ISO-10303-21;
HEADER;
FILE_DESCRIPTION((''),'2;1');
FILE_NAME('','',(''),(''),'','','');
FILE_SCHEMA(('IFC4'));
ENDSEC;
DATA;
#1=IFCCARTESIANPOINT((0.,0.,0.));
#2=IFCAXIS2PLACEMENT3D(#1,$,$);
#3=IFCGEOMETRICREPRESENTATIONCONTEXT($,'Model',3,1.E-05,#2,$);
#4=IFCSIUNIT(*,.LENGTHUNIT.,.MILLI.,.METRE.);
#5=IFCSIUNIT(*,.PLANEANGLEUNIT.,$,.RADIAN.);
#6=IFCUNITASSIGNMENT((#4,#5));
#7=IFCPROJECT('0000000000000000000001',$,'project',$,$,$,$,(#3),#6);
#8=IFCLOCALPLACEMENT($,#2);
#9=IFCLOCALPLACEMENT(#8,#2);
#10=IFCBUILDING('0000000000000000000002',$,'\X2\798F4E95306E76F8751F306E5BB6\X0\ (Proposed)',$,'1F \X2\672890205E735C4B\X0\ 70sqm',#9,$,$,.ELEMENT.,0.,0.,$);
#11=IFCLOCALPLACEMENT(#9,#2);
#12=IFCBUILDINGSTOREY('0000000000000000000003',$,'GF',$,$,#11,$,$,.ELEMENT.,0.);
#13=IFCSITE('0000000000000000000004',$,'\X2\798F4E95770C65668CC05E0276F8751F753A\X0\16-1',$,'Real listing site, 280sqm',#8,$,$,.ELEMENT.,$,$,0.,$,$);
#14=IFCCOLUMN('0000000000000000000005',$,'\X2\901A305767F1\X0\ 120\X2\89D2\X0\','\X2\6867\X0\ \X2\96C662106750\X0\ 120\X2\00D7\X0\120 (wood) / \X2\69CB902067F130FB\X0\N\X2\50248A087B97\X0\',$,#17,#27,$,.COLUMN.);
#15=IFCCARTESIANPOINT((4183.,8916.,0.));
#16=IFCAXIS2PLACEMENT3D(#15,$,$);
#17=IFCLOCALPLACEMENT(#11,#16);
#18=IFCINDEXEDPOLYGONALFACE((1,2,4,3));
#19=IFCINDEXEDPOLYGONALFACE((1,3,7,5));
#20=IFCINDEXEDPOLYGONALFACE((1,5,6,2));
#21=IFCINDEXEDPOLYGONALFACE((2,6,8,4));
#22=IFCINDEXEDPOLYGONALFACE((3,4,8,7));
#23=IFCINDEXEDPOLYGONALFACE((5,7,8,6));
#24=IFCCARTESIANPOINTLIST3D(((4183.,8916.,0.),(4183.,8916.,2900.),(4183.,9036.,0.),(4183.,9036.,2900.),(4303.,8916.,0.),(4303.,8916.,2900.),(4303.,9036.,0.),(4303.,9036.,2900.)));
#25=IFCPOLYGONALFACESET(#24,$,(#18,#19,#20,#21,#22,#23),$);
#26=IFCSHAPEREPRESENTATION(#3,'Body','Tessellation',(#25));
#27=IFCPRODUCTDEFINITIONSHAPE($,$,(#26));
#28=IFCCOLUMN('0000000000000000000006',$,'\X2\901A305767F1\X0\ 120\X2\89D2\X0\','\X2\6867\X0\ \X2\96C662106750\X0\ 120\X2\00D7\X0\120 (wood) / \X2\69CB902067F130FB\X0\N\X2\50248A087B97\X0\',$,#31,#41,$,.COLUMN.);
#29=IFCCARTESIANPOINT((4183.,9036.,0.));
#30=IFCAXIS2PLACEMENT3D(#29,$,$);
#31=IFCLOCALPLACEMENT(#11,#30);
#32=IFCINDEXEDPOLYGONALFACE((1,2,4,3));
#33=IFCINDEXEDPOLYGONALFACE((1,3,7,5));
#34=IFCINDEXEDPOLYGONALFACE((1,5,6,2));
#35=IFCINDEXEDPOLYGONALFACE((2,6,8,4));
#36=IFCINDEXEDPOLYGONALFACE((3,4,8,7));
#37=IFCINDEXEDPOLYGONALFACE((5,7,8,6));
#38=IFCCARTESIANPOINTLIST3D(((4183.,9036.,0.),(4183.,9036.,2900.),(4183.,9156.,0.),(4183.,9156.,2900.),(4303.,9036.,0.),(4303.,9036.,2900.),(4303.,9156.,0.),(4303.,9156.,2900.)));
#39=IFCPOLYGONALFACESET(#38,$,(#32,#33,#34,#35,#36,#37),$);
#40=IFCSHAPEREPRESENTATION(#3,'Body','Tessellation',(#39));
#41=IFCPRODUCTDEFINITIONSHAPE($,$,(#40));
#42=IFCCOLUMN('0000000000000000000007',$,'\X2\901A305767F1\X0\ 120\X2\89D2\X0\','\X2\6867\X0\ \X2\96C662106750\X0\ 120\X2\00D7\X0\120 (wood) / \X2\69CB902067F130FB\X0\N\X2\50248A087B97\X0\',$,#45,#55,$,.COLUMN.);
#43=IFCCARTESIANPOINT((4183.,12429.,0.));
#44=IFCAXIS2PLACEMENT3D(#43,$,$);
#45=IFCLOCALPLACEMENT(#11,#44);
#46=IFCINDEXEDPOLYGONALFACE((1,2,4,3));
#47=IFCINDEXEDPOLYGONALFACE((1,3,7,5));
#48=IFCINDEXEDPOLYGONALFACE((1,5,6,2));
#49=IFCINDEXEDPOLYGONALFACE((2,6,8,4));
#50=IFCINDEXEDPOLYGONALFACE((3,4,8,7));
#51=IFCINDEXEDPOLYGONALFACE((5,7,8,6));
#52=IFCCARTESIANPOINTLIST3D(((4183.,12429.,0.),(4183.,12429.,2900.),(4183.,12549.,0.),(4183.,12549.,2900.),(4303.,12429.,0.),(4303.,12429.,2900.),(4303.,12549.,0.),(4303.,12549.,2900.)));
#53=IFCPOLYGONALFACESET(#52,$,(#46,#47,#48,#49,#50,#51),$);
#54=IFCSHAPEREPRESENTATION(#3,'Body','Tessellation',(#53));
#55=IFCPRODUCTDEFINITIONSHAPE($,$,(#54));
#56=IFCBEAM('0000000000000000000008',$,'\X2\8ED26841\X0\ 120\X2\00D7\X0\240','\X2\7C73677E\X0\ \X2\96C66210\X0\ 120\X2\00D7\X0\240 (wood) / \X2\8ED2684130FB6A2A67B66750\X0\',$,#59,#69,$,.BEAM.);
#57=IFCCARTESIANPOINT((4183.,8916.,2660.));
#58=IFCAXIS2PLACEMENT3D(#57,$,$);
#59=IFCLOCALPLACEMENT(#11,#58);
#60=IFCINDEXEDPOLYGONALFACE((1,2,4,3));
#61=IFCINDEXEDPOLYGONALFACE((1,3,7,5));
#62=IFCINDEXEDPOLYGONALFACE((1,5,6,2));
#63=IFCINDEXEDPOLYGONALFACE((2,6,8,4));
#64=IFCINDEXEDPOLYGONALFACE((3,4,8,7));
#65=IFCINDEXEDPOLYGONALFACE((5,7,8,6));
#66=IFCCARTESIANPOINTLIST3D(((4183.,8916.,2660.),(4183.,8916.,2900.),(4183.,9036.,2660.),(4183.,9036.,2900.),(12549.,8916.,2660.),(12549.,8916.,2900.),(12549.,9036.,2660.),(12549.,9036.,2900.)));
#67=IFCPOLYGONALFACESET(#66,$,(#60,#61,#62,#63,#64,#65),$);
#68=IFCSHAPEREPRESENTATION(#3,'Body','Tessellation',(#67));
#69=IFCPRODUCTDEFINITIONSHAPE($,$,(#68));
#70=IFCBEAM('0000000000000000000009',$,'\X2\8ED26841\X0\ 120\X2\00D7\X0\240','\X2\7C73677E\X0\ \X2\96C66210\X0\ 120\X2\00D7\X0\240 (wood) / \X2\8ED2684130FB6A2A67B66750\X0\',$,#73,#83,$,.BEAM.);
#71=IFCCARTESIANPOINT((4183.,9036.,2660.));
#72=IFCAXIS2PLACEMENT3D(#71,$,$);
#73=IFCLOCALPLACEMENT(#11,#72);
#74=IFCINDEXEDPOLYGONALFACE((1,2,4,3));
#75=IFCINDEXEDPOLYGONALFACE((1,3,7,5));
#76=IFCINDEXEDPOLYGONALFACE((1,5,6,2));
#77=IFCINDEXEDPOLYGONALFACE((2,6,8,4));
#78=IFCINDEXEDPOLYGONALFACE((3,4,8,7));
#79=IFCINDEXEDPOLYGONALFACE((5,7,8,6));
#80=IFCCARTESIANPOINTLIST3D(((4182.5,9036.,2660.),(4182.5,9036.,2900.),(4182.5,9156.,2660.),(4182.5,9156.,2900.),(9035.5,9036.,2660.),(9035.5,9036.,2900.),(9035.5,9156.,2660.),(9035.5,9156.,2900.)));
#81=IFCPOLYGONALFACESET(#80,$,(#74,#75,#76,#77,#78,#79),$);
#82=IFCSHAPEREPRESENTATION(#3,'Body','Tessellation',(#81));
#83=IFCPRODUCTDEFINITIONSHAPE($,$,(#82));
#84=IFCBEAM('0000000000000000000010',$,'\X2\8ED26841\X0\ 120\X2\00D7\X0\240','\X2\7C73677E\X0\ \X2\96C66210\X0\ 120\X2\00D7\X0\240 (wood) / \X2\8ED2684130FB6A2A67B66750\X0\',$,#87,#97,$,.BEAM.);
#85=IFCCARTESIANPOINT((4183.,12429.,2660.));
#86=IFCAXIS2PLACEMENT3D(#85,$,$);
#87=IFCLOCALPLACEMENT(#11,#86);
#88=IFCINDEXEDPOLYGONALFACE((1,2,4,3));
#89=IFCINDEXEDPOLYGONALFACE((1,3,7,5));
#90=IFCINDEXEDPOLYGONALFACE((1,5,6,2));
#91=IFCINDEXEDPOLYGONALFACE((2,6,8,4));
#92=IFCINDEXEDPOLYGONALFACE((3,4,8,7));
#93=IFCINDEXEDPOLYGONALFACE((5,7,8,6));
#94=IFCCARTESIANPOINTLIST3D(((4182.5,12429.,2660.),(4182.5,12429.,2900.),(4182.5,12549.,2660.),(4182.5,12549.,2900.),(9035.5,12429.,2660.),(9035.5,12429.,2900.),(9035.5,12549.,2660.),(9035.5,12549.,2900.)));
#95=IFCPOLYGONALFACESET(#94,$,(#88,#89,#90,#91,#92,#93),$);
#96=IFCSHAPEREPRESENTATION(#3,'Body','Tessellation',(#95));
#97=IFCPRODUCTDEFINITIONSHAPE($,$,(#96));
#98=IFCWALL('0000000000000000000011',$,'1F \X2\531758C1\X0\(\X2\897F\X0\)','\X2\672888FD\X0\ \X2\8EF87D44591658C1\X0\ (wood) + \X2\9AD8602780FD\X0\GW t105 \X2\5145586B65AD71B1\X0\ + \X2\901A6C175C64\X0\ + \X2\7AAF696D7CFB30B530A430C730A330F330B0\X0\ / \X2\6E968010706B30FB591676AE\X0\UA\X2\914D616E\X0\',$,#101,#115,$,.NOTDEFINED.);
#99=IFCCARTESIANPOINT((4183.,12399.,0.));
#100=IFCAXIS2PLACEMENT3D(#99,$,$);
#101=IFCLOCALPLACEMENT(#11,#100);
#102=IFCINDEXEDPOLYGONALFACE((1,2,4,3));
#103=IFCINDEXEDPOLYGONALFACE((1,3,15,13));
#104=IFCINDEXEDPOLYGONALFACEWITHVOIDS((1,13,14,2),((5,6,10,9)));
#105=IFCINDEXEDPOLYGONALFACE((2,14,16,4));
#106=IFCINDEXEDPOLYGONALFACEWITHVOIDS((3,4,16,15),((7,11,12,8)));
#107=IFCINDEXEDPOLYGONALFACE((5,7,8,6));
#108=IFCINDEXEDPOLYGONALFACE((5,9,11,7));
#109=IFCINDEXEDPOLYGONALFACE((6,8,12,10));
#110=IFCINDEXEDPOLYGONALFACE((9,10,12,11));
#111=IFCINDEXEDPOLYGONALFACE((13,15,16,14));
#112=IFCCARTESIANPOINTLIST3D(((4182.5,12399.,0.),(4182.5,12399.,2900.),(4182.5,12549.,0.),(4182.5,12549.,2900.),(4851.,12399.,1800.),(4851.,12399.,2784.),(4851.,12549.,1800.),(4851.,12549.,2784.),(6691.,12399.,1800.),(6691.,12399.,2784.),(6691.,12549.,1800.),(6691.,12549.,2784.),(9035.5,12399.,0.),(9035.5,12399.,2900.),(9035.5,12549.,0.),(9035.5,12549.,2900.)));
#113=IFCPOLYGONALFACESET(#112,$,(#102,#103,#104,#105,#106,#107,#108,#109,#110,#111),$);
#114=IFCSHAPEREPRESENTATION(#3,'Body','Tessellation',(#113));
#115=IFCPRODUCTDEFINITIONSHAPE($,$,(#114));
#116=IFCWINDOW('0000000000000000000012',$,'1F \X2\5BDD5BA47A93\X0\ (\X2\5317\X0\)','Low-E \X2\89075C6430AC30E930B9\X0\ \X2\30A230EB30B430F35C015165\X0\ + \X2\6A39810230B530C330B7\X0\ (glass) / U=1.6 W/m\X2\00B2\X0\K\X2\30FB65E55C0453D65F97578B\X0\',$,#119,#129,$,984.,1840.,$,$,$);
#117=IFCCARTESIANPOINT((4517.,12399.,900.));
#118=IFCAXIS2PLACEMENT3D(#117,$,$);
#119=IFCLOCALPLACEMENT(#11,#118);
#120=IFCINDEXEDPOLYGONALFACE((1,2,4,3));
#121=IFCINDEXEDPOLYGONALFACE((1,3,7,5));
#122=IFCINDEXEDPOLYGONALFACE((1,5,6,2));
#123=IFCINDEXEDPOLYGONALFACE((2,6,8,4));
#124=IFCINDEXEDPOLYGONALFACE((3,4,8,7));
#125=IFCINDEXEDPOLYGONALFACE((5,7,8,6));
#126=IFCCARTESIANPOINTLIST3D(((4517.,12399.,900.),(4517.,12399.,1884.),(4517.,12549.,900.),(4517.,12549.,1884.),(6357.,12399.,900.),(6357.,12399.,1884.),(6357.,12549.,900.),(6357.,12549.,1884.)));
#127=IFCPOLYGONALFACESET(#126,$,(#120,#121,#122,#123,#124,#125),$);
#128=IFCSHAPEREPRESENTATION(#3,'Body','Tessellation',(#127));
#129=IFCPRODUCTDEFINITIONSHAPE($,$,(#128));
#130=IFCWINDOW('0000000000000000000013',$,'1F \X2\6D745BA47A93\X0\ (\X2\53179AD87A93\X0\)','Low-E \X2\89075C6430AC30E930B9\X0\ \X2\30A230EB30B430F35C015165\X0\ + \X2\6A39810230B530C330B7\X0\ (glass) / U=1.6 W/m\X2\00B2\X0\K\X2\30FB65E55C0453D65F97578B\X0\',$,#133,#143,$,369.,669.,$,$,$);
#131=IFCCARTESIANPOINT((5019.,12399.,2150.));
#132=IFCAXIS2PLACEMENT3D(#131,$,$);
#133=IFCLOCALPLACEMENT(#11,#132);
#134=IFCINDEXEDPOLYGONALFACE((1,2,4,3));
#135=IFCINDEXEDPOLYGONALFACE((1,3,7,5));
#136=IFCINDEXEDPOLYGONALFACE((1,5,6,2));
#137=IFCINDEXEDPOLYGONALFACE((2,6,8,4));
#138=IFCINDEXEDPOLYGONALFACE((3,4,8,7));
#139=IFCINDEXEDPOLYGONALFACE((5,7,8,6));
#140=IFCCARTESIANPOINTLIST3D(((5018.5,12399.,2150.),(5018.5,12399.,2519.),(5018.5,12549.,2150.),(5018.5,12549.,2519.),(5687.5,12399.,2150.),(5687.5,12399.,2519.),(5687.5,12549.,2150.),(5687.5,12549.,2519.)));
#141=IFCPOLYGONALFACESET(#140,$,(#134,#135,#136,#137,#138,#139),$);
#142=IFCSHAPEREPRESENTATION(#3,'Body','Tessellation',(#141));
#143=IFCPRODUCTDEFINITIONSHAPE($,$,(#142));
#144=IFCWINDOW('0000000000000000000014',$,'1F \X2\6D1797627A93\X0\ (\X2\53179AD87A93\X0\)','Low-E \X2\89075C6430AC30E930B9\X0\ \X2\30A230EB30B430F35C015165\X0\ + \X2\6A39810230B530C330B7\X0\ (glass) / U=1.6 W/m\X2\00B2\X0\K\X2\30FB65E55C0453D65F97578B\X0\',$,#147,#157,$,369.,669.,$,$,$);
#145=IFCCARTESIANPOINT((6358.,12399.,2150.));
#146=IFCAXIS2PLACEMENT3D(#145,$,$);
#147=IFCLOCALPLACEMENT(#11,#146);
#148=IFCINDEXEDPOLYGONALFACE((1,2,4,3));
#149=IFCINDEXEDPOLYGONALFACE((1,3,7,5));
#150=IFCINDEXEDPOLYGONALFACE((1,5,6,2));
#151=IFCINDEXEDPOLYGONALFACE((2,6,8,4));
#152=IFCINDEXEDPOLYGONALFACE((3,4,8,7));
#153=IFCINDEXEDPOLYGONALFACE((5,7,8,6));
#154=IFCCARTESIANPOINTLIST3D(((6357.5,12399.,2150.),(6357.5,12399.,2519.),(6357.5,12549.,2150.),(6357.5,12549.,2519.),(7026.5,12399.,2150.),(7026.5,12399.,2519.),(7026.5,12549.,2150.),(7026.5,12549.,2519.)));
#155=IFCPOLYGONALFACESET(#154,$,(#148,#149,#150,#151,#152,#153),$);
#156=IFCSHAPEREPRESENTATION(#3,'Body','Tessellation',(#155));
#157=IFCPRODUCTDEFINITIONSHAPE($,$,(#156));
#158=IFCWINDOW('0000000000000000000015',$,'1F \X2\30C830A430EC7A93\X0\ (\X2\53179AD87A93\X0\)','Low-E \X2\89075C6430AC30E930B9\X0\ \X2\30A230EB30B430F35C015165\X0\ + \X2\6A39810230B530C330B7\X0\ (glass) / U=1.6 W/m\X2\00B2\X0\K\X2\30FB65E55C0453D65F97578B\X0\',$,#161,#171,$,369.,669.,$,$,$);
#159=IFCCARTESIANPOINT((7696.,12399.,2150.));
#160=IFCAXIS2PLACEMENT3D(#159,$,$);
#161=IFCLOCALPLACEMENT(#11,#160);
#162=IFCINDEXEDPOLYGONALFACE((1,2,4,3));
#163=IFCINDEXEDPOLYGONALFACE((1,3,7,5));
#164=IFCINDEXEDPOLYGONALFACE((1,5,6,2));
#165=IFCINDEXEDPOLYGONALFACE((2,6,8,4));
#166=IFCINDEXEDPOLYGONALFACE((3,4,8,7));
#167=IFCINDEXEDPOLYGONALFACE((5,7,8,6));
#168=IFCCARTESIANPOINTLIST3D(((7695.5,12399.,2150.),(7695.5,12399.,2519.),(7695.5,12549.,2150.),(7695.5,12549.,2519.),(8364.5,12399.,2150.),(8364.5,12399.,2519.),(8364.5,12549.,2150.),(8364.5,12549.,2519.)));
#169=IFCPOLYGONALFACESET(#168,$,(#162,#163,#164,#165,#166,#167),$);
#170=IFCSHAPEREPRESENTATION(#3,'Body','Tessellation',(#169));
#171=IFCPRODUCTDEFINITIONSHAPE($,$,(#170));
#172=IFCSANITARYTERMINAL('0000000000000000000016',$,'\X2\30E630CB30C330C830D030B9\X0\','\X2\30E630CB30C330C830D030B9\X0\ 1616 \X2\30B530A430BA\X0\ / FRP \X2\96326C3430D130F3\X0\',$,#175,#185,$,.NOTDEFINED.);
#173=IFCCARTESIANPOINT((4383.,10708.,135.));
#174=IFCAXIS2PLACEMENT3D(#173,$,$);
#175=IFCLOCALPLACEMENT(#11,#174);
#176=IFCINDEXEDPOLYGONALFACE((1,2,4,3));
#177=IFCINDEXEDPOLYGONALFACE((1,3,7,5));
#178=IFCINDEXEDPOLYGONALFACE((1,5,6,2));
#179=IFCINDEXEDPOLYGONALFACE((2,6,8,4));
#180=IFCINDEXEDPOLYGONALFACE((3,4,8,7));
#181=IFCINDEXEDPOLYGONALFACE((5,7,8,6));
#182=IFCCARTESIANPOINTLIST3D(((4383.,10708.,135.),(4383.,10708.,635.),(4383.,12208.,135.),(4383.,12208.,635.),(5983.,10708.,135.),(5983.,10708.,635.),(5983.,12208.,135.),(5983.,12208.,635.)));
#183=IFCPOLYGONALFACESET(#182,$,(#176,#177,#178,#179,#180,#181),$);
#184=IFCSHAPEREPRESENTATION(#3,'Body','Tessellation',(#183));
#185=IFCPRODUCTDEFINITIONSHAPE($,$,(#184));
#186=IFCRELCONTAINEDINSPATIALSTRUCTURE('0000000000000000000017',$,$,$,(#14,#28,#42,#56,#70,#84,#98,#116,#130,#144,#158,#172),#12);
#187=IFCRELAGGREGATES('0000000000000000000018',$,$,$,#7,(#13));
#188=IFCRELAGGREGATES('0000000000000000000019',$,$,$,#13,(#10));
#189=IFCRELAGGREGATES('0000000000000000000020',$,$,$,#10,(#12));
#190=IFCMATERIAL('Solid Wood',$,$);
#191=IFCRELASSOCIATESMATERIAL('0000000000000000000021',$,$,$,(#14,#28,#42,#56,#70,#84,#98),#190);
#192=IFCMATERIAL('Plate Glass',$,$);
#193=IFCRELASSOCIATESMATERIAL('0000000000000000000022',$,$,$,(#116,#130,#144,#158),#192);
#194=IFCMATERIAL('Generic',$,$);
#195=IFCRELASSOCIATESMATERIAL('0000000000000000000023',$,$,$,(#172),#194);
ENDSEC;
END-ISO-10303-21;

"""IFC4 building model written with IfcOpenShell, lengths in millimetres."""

from ifc_helpers import new_model, si_unit, frame, frame_2d, origin, place, context, project, spatial, rectangle, extrude, material, element, fill, save


model = new_model("IFC4")

# Units and contexts
model_context = context("Model", 3, precision=1e-05, world=origin())
ifc_project = project(units=[si_unit("LENGTHUNIT", "METRE", prefix="MILLI"), si_unit("PLANEANGLEUNIT", "RADIAN")], contexts=[model_context])

# Site, building, storey
site_placement = place(None, origin())
site = spatial("IfcSite", under=ifc_project, at=site_placement, Name="福井県敦賀市相生町16-1", ObjectType="Real listing site, 280sqm", CompositionType="ELEMENT", RefElevation=0.0)
building_placement = place(site_placement, origin())
building = spatial("IfcBuilding", under=site, at=building_placement, Name="福井の相生の家 (Proposed)", ObjectType="1F 木造平屋 70sqm", CompositionType="ELEMENT", ElevationOfRefHeight=0.0, ElevationOfTerrain=0.0)
storey_placement = place(building_placement, origin())
storey = spatial("IfcBuildingStorey", under=building, at=storey_placement, Name="GF", CompositionType="ELEMENT", Elevation=0.0)

# Columns
ifc_material_1 = material(Name="Solid Wood")
column_1_placement = place(storey_placement, frame((4183.0, 8916.0, 0.0)))
element("IfcColumn", 1, at=column_1_placement, inside=storey, material=ifc_material_1, Name="通し柱 120角", Description="桧 集成材 120×120 (wood) / 構造柱・N値計算", PredefinedType="COLUMN", context=model_context, shape_type="SweptSolid", body=[
    extrude(rectangle(XDim=120.0, YDim=120.0, at=frame_2d((60.0, 60.0))), frame((4183.0, 8916.0, 0.0)), (0.0, 0.0, 1.0), 2900.0),
])
column_2_placement = place(storey_placement, frame((4183.0, 9036.0, 0.0)))
element("IfcColumn", 2, at=column_2_placement, inside=storey, material=ifc_material_1, Name="通し柱 120角", Description="桧 集成材 120×120 (wood) / 構造柱・N値計算", PredefinedType="COLUMN", context=model_context, shape_type="SweptSolid", body=[
    extrude(rectangle(XDim=120.0, YDim=120.0, at=frame_2d((60.0, 60.0))), frame((4183.0, 9036.0, 0.0)), (0.0, 0.0, 1.0), 2900.0),
])
column_3_placement = place(storey_placement, frame((4183.0, 12429.0, 0.0)))
element("IfcColumn", 3, at=column_3_placement, inside=storey, material=ifc_material_1, Name="通し柱 120角", Description="桧 集成材 120×120 (wood) / 構造柱・N値計算", PredefinedType="COLUMN", context=model_context, shape_type="SweptSolid", body=[
    extrude(rectangle(XDim=120.0, YDim=120.0, at=frame_2d((60.0, 60.0))), frame((4183.0, 12429.0, 0.0)), (0.0, 0.0, 1.0), 2900.0),
])

# Beams
beam_1_placement = place(storey_placement, frame((4183.0, 8916.0, 2660.0)))
element("IfcBeam", 4, at=beam_1_placement, inside=storey, material=ifc_material_1, Name="軒桁 120×240", Description="米松 集成 120×240 (wood) / 軒桁・横架材", PredefinedType="BEAM", context=model_context, shape_type="SweptSolid", body=[
    extrude(rectangle(XDim=8366.0, YDim=120.0, at=frame_2d((4183.0, 60.0))), frame((4183.0, 8916.0, 2660.0)), (0.0, 0.0, 1.0), 240.0),
])
beam_2_placement = place(storey_placement, frame((4183.0, 9036.0, 2660.0)))
element("IfcBeam", 5, at=beam_2_placement, inside=storey, material=ifc_material_1, Name="軒桁 120×240", Description="米松 集成 120×240 (wood) / 軒桁・横架材", PredefinedType="BEAM", context=model_context, shape_type="SweptSolid", body=[
    extrude(rectangle(XDim=4853.0, YDim=120.0, at=frame_2d((2426.0, 60.0))), frame((4183.0, 9036.0, 2660.0)), (0.0, 0.0, 1.0), 240.0),
])
beam_3_placement = place(storey_placement, frame((4183.0, 12429.0, 2660.0)))
element("IfcBeam", 6, at=beam_3_placement, inside=storey, material=ifc_material_1, Name="軒桁 120×240", Description="米松 集成 120×240 (wood) / 軒桁・横架材", PredefinedType="BEAM", context=model_context, shape_type="SweptSolid", body=[
    extrude(rectangle(XDim=4853.0, YDim=120.0, at=frame_2d((2426.0, 60.0))), frame((4183.0, 12429.0, 2660.0)), (0.0, 0.0, 1.0), 240.0),
])

# Wall, openings, windows
wall_1_placement = place(storey_placement, frame((4183.0, 12399.0, 0.0)))
wall_1 = element("IfcWall", 7, at=wall_1_placement, inside=storey, material=ifc_material_1, Name="1F 北壁(西)", Description="木製 軸組外壁 (wood) + 高性能GW t105 充填断熱 + 通気層 + 窯業系サイディング / 準耐火・外皮UA配慮", PredefinedType="NOTDEFINED", context=model_context, shape_type="SweptSolid", body=[
    extrude(rectangle(XDim=4853.0, YDim=150.0, at=frame_2d((2426.0, 75.0))), frame((4183.0, 12399.0, 0.0)), (0.0, 0.0, 1.0), 2900.0),
])
opening_1_placement = place(storey_placement, frame((4517.0, 12399.0, 900.0)))
opening_1 = element("IfcOpeningElement", 8, at=opening_1_placement, cuts=wall_1, PredefinedType="NOTDEFINED", context=model_context, shape_type="SweptSolid", body=[
    extrude(rectangle(XDim=1840.0, YDim=150.0, at=frame_2d((920.0, 75.0))), frame((4517.0, 12399.0, 900.0)), (0.0, 0.0, 1.0), 984.0),
])
opening_2_placement = place(storey_placement, frame((5019.0, 12399.0, 2150.0)))
opening_2 = element("IfcOpeningElement", 9, at=opening_2_placement, cuts=wall_1, PredefinedType="NOTDEFINED", context=model_context, shape_type="SweptSolid", body=[
    extrude(rectangle(XDim=669.0, YDim=150.0, at=frame_2d((334.0, 75.0))), frame((5019.0, 12399.0, 2150.0)), (0.0, 0.0, 1.0), 369.0),
])
opening_3_placement = place(storey_placement, frame((6358.0, 12399.0, 2150.0)))
opening_3 = element("IfcOpeningElement", 10, at=opening_3_placement, cuts=wall_1, PredefinedType="NOTDEFINED", context=model_context, shape_type="SweptSolid", body=[
    extrude(rectangle(XDim=669.0, YDim=150.0, at=frame_2d((334.0, 75.0))), frame((6358.0, 12399.0, 2150.0)), (0.0, 0.0, 1.0), 369.0),
])
opening_4_placement = place(storey_placement, frame((7696.0, 12399.0, 2150.0)))
opening_4 = element("IfcOpeningElement", 11, at=opening_4_placement, cuts=wall_1, PredefinedType="NOTDEFINED", context=model_context, shape_type="SweptSolid", body=[
    extrude(rectangle(XDim=669.0, YDim=150.0, at=frame_2d((334.0, 75.0))), frame((7696.0, 12399.0, 2150.0)), (0.0, 0.0, 1.0), 369.0),
])
ifc_material_2 = material(Name="Plate Glass")
window_1_placement = place(storey_placement, frame((4517.0, 12399.0, 900.0)))
window_1 = element("IfcWindow", 12, at=window_1_placement, inside=storey, material=ifc_material_2, Name="1F 寝室窓 (北)", Description="Low-E 複層ガラス アルゴン封入 + 樹脂サッシ (glass) / U=1.6 W/m²K・日射取得型", OverallHeight=984.0, OverallWidth=1840.0, context=model_context, shape_type="SweptSolid", body=[
    extrude(rectangle(XDim=1840.0, YDim=150.0, at=frame_2d((920.0, 75.0))), frame((4517.0, 12399.0, 900.0)), (0.0, 0.0, 1.0), 984.0),
])
fill(opening_1, window_1)
window_2_placement = place(storey_placement, frame((5019.0, 12399.0, 2150.0)))
window_2 = element("IfcWindow", 13, at=window_2_placement, inside=storey, material=ifc_material_2, Name="1F 浴室窓 (北高窓)", Description="Low-E 複層ガラス アルゴン封入 + 樹脂サッシ (glass) / U=1.6 W/m²K・日射取得型", OverallHeight=369.0, OverallWidth=669.0, context=model_context, shape_type="SweptSolid", body=[
    extrude(rectangle(XDim=669.0, YDim=150.0, at=frame_2d((334.0, 75.0))), frame((5019.0, 12399.0, 2150.0)), (0.0, 0.0, 1.0), 369.0),
])
fill(opening_2, window_2)
window_3_placement = place(storey_placement, frame((6358.0, 12399.0, 2150.0)))
window_3 = element("IfcWindow", 14, at=window_3_placement, inside=storey, material=ifc_material_2, Name="1F 洗面窓 (北高窓)", Description="Low-E 複層ガラス アルゴン封入 + 樹脂サッシ (glass) / U=1.6 W/m²K・日射取得型", OverallHeight=369.0, OverallWidth=669.0, context=model_context, shape_type="SweptSolid", body=[
    extrude(rectangle(XDim=669.0, YDim=150.0, at=frame_2d((334.0, 75.0))), frame((6358.0, 12399.0, 2150.0)), (0.0, 0.0, 1.0), 369.0),
])
fill(opening_3, window_3)
window_4_placement = place(storey_placement, frame((7696.0, 12399.0, 2150.0)))
window_4 = element("IfcWindow", 15, at=window_4_placement, inside=storey, material=ifc_material_2, Name="1F トイレ窓 (北高窓)", Description="Low-E 複層ガラス アルゴン封入 + 樹脂サッシ (glass) / U=1.6 W/m²K・日射取得型", OverallHeight=369.0, OverallWidth=669.0, context=model_context, shape_type="SweptSolid", body=[
    extrude(rectangle(XDim=669.0, YDim=150.0, at=frame_2d((334.0, 75.0))), frame((7696.0, 12399.0, 2150.0)), (0.0, 0.0, 1.0), 369.0),
])
fill(opening_4, window_4)

# Shared definitions
ifc_material_3 = material(Name="Generic")

# Sanitary terminal
sanitary_terminal_placement = place(storey_placement, frame((4383.0, 10708.0, 135.0)))
element("IfcSanitaryTerminal", 16, at=sanitary_terminal_placement, inside=storey, material=ifc_material_3, Name="ユニットバス", Description="ユニットバス 1616 サイズ / FRP 防水パン", PredefinedType="NOTDEFINED", context=model_context, shape_type="SweptSolid", body=[
    extrude(rectangle(XDim=1600.0, YDim=1500.0, at=frame_2d((800.0, 750.0))), frame((4383.0, 10708.0, 135.0)), (0.0, 0.0, 1.0), 500.0),
])

save(model, "model.ifc")
